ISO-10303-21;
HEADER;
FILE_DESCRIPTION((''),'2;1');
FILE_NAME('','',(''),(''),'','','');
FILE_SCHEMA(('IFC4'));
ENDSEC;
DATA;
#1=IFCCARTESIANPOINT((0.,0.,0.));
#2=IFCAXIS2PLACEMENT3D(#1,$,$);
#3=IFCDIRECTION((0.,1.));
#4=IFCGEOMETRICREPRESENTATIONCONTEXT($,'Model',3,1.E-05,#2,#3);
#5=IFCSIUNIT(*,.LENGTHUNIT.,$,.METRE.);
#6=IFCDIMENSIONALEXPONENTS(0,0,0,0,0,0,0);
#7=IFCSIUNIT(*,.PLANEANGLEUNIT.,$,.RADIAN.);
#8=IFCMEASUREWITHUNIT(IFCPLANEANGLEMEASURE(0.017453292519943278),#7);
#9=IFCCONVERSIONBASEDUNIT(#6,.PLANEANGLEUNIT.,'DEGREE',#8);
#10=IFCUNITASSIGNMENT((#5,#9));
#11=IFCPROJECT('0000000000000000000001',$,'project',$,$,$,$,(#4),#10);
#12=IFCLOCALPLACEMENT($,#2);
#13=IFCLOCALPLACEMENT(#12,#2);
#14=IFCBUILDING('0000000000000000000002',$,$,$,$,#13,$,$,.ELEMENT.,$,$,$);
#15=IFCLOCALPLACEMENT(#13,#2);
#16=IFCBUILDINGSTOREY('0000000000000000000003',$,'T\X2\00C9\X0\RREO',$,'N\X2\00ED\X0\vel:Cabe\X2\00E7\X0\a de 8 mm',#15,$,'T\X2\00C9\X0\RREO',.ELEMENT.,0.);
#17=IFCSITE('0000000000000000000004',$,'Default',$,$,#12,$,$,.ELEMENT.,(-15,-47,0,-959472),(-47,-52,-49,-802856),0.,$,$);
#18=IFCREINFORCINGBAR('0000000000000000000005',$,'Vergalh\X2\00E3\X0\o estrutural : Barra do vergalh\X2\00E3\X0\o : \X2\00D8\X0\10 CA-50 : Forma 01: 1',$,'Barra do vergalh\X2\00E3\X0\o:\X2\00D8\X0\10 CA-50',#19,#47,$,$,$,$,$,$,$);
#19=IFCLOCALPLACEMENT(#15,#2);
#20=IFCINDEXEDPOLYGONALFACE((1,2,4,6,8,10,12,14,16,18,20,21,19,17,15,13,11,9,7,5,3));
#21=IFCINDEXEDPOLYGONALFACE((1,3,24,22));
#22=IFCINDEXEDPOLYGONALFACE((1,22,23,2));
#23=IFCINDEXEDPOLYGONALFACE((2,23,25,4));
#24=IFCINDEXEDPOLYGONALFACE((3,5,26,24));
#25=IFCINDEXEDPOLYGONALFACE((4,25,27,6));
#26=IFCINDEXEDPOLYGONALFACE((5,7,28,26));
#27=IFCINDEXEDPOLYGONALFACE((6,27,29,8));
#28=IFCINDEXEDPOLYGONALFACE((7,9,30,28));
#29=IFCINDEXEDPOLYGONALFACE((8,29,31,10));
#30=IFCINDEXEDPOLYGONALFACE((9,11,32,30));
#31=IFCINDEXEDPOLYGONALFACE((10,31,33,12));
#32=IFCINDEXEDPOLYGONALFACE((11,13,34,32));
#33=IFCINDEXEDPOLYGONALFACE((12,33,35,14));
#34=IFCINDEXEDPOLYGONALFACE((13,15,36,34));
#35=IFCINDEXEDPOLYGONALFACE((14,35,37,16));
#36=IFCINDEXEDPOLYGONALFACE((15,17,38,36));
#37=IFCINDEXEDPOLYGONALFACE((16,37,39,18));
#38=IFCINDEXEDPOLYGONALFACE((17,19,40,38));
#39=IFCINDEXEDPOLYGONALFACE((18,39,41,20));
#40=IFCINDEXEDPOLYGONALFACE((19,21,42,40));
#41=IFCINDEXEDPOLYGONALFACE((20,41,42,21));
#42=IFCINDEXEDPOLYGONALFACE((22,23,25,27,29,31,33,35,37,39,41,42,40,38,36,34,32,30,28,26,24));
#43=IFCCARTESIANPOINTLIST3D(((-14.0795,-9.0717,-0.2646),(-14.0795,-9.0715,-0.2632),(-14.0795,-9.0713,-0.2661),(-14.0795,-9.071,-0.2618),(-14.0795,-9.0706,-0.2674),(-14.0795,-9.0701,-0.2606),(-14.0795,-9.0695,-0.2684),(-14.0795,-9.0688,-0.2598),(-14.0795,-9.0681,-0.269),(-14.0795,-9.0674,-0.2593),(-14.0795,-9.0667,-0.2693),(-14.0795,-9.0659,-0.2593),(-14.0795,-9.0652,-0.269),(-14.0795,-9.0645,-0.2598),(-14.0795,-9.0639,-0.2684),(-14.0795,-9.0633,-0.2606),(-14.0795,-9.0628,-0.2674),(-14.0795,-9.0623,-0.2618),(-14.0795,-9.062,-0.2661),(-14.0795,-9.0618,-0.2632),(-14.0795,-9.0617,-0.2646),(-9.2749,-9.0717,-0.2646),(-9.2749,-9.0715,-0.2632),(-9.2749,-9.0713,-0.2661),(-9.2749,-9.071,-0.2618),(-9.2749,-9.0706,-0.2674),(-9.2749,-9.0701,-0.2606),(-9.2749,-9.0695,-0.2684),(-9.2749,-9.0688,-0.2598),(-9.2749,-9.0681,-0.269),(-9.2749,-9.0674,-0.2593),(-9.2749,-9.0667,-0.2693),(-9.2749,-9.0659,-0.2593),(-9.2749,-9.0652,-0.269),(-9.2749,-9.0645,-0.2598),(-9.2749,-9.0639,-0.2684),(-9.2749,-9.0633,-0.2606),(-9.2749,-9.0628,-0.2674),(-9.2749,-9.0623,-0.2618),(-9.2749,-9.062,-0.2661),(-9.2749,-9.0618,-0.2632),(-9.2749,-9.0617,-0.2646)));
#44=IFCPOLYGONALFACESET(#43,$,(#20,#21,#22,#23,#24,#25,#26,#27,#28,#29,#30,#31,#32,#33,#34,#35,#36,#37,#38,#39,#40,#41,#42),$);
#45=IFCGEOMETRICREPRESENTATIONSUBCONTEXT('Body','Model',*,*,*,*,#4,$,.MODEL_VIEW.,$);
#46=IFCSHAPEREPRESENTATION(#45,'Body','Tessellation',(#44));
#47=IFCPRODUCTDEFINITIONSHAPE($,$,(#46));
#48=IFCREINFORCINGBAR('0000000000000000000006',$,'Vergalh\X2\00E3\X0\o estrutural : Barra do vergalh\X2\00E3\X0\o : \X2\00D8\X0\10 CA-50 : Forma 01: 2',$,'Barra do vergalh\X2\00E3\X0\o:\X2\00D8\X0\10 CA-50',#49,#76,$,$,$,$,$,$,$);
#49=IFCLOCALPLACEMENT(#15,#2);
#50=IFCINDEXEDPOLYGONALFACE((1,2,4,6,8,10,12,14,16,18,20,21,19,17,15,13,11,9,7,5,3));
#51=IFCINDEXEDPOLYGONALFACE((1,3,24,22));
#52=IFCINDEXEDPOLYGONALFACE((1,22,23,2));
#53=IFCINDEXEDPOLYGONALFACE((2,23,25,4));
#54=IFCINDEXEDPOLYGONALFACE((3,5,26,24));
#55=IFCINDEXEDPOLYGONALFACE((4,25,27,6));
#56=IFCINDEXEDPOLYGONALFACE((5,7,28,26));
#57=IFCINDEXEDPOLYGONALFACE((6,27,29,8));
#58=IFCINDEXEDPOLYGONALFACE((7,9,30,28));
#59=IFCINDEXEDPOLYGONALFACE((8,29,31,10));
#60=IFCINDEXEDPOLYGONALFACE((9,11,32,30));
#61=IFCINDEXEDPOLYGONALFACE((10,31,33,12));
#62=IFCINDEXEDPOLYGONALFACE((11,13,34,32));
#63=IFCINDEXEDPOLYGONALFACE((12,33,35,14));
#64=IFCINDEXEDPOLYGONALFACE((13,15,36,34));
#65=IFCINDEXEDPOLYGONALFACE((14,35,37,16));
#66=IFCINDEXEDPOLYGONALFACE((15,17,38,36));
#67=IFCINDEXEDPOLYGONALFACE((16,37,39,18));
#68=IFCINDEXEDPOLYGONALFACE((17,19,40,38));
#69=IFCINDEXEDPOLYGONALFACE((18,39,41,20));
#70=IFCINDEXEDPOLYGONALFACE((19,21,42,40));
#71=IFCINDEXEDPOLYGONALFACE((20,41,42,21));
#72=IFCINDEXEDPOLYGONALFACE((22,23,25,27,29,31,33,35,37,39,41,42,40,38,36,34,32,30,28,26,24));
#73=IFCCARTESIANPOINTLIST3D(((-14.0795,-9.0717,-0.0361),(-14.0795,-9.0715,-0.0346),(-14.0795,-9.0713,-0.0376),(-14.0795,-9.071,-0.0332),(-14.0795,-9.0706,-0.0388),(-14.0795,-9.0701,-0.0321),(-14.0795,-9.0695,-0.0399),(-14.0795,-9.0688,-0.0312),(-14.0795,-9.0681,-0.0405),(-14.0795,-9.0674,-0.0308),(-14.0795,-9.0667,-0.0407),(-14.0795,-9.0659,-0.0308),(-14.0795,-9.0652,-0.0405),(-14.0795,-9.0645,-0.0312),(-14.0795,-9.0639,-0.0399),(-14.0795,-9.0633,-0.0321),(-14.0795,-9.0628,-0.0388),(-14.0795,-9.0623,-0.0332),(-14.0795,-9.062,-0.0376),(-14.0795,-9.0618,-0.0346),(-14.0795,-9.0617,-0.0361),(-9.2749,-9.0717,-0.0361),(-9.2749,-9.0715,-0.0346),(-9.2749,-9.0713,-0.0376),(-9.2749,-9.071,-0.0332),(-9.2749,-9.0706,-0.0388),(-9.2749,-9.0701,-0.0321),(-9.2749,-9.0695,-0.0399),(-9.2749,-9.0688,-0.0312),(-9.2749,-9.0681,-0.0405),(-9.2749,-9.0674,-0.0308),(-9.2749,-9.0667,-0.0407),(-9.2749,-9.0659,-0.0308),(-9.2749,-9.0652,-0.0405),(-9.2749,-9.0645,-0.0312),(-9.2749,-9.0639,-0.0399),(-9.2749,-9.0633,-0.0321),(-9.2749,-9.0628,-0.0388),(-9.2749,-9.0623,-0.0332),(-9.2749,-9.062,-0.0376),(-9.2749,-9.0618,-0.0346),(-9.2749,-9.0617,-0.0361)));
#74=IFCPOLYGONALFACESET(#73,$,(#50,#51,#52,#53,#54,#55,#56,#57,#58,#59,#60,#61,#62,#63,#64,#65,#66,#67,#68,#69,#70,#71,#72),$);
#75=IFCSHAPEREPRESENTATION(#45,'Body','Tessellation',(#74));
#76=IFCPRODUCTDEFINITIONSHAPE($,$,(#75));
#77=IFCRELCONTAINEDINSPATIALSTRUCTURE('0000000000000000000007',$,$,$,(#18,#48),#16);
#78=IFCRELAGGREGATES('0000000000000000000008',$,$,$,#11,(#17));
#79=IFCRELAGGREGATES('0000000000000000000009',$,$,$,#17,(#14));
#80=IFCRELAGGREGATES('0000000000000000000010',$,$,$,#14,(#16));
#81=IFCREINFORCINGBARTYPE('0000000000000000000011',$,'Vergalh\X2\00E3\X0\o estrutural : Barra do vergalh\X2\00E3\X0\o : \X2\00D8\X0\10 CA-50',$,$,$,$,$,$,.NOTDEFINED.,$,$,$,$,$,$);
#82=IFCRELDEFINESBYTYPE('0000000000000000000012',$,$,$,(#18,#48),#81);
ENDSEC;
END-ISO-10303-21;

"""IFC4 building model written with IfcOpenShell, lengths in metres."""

from ifc_helpers import new_model, entity, si_unit, converted_unit, direction, origin, place, context, subcontext, project, spatial, type_object, element, save


model = new_model("IFC4")

# Units and contexts
model_context = context("Model", 3, precision=1e-05, world=origin(), true_north=direction((0.0, 1.0)))
body_context = subcontext(model_context, "Body", "Model", "MODEL_VIEW")
ifc_project = project(units=[si_unit("LENGTHUNIT", "METRE"), converted_unit("PLANEANGLEUNIT", "DEGREE", entity("IfcPlaneAngleMeasure", 0.017453292519943278), si_unit("PLANEANGLEUNIT", "RADIAN"), dimensions=[0, 0, 0, 0, 0, 0, 0])], contexts=[model_context])

# Site, building, storey
site_placement = place(None, origin())
site = spatial("IfcSite", under=ifc_project, at=site_placement, Name="Default", CompositionType="ELEMENT", RefLatitude=(-15, -47, 0, -959472), RefLongitude=(-47, -52, -49, -802856), RefElevation=0.0)
building_placement = place(site_placement, origin())
building = spatial("IfcBuilding", under=site, at=building_placement, CompositionType="ELEMENT")
storey_placement = place(building_placement, origin())
storey = spatial("IfcBuildingStorey", under=building, at=storey_placement, Name="TÉRREO", ObjectType="Nível:Cabeça de 8 mm", LongName="TÉRREO", CompositionType="ELEMENT", Elevation=0.0)

# Reinforcing bars
reinforcing_bar_type_1 = type_object("IfcReinforcingBarType", Name="Vergalhão estrutural : Barra do vergalhão : Ø10 CA-50", PredefinedType="NOTDEFINED")
reinforcing_bar_1_placement = place(storey_placement, origin())
element("IfcReinforcingBar", 1, at=reinforcing_bar_1_placement, inside=storey, type_object=reinforcing_bar_type_1, Name="Vergalhão estrutural : Barra do vergalhão : Ø10 CA-50 : Forma 01: 1", ObjectType="Barra do vergalhão:Ø10 CA-50", context=body_context, shape_type="AdvancedSweptSolid", body=[
    entity("IfcSweptDiskSolid", entity("IfcIndexedPolyCurve", entity("IfcCartesianPointList3D", [[-9.2749, -9.0667, -0.2643], [-14.0795, -9.0667, -0.2643]]), None, False), 0.005, None, 0.0, 1.0),
])
reinforcing_bar_2_placement = place(storey_placement, origin())
element("IfcReinforcingBar", 2, at=reinforcing_bar_2_placement, inside=storey, type_object=reinforcing_bar_type_1, Name="Vergalhão estrutural : Barra do vergalhão : Ø10 CA-50 : Forma 01: 2", ObjectType="Barra do vergalhão:Ø10 CA-50", context=body_context, shape_type="AdvancedSweptSolid", body=[
    entity("IfcSweptDiskSolid", entity("IfcIndexedPolyCurve", entity("IfcCartesianPointList3D", [[-9.2749, -9.0667, -0.0357], [-14.0795, -9.0667, -0.0357]]), None, False), 0.005, None, 0.0, 1.0),
])

save(model, "model.ifc")
